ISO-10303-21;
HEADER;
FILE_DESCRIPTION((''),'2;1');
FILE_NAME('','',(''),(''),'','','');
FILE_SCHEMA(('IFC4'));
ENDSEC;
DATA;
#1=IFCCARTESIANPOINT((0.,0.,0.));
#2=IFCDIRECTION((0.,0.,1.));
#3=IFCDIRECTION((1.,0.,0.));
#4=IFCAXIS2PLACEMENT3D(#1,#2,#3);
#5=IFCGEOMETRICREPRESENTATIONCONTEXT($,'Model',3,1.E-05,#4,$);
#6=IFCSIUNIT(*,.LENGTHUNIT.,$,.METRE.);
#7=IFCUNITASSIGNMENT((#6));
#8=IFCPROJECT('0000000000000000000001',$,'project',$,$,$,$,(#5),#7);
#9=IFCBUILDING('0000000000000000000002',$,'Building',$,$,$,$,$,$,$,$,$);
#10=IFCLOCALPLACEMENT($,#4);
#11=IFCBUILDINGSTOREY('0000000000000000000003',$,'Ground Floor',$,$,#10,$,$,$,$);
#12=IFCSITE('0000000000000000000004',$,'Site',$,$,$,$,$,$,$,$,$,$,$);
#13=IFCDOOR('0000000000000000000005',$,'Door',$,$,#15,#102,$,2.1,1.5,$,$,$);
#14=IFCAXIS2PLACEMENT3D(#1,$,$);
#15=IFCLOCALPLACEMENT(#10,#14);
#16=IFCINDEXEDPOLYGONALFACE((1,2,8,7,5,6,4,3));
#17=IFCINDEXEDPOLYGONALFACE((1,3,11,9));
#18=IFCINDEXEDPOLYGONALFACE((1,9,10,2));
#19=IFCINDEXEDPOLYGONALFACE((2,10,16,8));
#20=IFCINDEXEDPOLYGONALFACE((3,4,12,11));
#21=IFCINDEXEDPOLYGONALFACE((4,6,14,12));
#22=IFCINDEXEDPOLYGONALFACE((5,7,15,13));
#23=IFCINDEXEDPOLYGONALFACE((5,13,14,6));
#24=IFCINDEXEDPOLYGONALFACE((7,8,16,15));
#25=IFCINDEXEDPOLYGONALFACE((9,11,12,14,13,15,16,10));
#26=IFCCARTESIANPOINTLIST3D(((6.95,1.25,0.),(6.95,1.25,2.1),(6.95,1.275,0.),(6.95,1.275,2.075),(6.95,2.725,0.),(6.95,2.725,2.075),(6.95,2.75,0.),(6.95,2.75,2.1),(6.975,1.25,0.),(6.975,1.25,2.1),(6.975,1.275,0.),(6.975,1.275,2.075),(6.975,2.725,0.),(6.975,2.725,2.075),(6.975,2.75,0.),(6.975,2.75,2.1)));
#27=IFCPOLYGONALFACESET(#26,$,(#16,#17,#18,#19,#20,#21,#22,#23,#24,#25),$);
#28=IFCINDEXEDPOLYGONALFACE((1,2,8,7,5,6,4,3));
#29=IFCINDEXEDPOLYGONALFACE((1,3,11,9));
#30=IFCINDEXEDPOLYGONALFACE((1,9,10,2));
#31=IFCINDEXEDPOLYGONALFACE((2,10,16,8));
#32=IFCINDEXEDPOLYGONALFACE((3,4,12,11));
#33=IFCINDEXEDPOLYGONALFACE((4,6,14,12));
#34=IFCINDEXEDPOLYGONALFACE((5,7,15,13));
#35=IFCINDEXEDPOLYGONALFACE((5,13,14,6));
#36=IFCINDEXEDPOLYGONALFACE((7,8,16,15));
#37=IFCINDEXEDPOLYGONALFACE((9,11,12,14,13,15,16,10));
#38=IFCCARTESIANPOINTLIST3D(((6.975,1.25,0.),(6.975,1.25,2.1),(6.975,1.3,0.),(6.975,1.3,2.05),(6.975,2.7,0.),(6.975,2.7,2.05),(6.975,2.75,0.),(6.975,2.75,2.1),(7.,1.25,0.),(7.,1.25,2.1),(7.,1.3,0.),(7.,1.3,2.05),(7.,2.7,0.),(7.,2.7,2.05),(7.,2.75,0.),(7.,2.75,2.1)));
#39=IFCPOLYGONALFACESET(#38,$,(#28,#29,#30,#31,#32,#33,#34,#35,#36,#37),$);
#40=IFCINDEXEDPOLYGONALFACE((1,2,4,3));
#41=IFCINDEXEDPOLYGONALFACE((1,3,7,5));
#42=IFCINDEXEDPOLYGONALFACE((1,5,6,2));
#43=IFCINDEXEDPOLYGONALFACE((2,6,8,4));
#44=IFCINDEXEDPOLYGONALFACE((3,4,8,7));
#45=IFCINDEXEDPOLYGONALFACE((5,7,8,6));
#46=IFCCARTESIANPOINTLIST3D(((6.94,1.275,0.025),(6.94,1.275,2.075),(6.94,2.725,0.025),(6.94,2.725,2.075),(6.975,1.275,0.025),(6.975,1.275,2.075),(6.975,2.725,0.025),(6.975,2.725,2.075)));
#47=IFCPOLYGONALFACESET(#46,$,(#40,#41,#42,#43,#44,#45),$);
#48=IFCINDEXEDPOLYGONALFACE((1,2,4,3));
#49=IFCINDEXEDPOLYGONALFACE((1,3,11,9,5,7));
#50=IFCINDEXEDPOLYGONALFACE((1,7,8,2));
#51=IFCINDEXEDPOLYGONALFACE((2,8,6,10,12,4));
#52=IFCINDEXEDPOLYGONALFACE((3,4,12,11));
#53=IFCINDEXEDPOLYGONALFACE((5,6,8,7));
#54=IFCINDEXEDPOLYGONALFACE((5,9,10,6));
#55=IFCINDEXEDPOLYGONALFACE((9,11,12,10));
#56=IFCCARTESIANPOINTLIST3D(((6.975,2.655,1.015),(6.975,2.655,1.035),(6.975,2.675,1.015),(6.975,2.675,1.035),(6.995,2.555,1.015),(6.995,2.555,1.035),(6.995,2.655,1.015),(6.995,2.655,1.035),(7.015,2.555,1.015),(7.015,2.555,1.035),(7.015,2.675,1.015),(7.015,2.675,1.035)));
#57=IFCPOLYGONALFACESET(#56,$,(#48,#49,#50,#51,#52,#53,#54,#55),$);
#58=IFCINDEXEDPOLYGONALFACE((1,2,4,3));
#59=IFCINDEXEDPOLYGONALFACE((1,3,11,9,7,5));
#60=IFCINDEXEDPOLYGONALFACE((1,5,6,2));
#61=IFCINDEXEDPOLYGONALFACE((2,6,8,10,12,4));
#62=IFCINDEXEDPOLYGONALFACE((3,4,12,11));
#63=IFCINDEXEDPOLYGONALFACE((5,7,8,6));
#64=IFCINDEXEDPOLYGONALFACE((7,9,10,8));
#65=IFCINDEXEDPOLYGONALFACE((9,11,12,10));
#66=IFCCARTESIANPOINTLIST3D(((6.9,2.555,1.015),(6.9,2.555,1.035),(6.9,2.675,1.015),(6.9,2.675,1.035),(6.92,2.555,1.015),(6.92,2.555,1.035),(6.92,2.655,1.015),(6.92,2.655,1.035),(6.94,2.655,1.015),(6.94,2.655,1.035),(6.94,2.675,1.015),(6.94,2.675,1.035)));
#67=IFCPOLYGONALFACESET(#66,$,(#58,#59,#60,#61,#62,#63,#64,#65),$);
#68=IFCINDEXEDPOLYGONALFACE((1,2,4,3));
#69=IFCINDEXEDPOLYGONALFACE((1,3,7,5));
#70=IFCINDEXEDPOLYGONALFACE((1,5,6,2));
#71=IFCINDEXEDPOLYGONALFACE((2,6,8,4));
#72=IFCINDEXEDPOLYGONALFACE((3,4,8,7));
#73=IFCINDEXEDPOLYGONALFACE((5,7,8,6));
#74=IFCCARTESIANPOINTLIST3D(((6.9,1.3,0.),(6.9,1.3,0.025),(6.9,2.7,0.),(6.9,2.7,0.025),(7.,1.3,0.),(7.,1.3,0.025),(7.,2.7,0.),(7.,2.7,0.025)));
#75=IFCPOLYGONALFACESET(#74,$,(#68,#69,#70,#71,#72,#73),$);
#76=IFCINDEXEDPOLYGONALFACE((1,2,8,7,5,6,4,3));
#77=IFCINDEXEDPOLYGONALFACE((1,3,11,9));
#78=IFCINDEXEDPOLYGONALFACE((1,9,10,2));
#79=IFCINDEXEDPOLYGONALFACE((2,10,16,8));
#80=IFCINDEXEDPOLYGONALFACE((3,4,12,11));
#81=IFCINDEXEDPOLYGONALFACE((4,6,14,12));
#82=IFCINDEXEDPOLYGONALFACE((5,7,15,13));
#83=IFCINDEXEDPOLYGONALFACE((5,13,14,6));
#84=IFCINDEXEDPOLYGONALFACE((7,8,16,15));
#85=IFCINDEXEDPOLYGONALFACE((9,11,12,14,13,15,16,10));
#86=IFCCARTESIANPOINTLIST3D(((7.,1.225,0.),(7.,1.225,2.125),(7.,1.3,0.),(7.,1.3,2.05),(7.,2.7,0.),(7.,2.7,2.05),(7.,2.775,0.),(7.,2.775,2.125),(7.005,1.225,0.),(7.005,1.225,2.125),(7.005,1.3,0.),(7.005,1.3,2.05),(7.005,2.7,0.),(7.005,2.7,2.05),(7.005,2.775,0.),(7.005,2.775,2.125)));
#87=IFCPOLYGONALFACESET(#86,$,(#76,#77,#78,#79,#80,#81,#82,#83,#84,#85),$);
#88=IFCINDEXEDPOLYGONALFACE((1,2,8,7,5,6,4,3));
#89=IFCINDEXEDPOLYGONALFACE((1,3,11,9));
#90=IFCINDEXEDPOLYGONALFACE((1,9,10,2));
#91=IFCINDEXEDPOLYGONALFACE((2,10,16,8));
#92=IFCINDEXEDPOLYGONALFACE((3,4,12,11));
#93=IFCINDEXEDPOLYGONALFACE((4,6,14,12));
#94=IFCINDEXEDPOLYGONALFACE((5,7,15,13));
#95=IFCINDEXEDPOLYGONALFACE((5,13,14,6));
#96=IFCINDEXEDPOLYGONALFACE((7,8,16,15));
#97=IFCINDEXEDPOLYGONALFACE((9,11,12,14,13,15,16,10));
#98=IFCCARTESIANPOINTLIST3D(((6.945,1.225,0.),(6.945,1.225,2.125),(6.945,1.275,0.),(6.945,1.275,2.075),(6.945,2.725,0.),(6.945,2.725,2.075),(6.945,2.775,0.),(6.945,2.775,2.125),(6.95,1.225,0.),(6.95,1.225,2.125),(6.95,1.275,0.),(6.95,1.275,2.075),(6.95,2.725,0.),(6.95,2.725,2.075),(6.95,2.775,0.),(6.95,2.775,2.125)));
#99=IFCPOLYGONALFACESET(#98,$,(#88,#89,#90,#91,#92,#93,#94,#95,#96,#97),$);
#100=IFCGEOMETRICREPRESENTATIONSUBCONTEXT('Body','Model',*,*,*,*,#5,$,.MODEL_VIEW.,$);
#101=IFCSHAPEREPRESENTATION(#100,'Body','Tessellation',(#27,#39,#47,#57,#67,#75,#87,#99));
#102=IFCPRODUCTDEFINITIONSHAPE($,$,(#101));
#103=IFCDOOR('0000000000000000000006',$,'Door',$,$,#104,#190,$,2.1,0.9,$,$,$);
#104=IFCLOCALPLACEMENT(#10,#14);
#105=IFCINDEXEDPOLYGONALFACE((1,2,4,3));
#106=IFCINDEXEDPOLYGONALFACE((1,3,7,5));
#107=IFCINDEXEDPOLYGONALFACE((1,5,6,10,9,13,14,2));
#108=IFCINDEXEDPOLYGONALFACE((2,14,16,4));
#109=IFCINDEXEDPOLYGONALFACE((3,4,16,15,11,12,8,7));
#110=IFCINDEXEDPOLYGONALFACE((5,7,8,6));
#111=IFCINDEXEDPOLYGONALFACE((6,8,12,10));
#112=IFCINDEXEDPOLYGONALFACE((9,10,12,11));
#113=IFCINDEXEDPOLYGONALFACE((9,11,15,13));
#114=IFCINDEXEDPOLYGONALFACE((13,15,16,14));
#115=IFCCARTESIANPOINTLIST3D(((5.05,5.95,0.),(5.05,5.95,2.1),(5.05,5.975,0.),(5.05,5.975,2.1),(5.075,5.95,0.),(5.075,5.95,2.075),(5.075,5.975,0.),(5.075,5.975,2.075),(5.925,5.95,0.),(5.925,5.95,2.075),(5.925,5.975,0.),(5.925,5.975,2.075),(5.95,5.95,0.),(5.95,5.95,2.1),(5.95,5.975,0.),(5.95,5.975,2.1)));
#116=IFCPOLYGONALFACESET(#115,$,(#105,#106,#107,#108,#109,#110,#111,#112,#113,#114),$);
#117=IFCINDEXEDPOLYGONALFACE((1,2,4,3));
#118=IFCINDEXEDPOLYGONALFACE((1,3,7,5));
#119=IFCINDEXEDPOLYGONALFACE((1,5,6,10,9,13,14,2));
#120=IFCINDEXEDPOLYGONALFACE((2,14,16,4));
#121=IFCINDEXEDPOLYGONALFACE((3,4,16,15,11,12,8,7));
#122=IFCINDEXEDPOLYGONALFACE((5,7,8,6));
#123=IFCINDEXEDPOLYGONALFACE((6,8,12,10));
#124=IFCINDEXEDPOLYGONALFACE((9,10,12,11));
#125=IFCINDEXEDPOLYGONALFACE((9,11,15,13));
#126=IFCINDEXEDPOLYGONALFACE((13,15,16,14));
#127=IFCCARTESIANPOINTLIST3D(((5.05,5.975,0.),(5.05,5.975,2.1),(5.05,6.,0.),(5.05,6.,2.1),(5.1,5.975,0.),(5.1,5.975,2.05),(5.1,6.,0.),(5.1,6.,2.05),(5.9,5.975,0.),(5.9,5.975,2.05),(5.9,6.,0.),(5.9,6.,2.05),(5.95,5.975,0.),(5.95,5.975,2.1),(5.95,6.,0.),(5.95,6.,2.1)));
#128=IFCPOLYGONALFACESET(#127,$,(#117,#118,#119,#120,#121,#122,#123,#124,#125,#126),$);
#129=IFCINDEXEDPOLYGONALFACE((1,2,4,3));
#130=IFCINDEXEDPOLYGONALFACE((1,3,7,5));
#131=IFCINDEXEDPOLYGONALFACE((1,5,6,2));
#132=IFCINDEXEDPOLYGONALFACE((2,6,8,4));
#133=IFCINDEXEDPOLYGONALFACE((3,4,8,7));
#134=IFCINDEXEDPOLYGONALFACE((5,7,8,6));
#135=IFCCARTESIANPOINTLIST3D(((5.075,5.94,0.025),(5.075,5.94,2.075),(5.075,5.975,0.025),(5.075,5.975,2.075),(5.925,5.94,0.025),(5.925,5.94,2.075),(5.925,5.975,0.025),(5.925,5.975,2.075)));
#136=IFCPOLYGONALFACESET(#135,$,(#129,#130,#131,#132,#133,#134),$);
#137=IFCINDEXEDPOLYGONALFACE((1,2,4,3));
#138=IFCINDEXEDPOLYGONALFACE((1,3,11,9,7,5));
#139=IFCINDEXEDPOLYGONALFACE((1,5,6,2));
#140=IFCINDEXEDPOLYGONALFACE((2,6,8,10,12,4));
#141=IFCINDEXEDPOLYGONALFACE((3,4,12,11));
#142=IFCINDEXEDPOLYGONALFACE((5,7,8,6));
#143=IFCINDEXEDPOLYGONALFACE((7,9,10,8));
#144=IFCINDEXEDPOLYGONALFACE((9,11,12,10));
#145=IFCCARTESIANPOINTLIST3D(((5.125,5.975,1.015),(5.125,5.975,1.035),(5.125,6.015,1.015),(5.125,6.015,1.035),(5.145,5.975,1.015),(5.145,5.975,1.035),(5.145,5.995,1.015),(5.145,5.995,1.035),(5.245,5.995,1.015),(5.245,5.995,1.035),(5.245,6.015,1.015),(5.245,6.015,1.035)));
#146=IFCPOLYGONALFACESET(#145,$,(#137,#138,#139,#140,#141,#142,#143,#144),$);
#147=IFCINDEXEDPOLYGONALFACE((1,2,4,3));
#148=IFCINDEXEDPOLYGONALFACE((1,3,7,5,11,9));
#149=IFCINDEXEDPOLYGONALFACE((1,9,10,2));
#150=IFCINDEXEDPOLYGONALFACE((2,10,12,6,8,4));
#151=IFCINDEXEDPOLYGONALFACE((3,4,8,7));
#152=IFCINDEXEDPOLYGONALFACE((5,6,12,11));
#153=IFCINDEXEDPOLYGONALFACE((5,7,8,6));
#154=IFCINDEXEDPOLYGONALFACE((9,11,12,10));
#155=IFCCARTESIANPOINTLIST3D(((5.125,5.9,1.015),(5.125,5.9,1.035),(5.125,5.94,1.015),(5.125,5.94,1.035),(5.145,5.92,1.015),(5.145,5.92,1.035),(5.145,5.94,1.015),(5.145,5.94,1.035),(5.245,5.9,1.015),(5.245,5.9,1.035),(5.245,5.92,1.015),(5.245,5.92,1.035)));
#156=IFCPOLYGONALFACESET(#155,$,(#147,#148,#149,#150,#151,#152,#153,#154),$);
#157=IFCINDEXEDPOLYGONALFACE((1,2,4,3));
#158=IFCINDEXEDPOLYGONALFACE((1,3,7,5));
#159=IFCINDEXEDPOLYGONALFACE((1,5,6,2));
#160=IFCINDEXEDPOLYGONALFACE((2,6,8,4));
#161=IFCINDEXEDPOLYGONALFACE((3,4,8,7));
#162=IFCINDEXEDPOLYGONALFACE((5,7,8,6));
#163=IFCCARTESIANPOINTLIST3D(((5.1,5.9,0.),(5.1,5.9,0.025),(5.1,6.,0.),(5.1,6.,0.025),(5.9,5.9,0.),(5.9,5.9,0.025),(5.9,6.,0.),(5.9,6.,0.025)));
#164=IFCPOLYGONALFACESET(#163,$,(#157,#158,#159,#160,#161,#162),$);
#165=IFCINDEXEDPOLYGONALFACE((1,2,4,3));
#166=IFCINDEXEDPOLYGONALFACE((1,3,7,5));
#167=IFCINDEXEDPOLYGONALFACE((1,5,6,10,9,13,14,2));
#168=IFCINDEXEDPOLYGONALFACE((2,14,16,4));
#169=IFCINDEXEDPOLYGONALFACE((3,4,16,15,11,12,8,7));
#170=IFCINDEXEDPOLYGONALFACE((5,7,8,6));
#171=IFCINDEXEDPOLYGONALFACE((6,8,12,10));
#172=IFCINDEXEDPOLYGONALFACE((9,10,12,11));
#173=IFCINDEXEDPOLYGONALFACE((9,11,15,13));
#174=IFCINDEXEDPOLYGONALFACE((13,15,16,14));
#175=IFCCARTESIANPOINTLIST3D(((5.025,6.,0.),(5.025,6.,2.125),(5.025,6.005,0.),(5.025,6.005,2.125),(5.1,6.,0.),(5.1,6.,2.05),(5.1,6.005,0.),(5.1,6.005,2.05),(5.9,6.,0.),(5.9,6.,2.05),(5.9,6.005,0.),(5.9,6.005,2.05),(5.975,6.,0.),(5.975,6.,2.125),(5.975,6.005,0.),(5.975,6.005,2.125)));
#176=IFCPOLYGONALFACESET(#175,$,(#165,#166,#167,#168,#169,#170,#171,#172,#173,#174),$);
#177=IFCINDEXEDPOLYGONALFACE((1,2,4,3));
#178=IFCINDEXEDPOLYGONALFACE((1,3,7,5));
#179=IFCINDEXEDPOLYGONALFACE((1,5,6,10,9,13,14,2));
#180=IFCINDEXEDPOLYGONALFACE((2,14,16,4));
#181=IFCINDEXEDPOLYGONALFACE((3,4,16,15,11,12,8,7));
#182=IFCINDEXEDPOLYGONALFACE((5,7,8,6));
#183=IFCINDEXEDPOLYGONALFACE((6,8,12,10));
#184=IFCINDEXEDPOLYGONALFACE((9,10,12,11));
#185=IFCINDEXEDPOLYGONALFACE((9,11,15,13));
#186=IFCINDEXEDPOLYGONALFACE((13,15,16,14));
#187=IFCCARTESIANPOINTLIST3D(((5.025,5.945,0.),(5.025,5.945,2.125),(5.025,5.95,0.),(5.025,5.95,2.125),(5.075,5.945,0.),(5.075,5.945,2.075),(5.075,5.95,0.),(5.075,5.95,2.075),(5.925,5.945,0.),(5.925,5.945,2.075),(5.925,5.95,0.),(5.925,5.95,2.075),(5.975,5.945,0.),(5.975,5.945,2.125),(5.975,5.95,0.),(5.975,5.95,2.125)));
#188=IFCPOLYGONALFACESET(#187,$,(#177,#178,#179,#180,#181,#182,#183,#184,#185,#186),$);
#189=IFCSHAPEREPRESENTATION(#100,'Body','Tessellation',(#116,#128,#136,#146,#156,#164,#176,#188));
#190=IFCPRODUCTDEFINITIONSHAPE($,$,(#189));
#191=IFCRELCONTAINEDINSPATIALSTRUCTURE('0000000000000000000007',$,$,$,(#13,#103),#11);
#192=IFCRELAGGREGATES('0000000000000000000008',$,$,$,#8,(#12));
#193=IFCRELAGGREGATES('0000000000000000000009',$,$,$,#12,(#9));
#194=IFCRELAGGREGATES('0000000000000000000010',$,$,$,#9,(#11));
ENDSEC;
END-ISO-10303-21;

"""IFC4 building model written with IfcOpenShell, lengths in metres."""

from ifc_helpers import new_model, si_unit, frame, origin_with_axes, place, context, subcontext, project, spatial, line, indexed_curve, outline, extrude, element, save


model = new_model("IFC4")

# Units and contexts
model_context = context("Model", 3, precision=1e-05, world=origin_with_axes())
body_context = subcontext(model_context, "Body", "Model", "MODEL_VIEW")
ifc_project = project(units=[si_unit("LENGTHUNIT", "METRE")], contexts=[model_context])

# Site, building, storey
site = spatial("IfcSite", under=ifc_project, Name="Site")
building = spatial("IfcBuilding", under=site, Name="Building")
storey_placement = place(None, origin_with_axes())
storey = spatial("IfcBuildingStorey", under=building, at=storey_placement, Name="Ground Floor")

# Doors
door_1_placement = place(storey_placement, frame((7.0, 1.25, 0.0), z_axis=(0.0, 0.0, 1.0), x_axis=(0.0, 1.0, 0.0)))
element("IfcDoor", 1, at=door_1_placement, inside=storey, Name="Door", OverallHeight=2.1, OverallWidth=1.5, context=body_context, shape_type="SweptSolid", body=[
    extrude(outline(indexed_curve([(0.0, 0.0), (0.0, 2.1), (1.5, 2.1), (1.5, 0.0), (1.475, 0.0), (1.475, 2.075), (0.025, 2.075), (0.025, 0.0)], segments=[line(1, 2, 3, 4, 5, 6, 7, 8, 1)])), frame((0.0, 0.025, 0.0), z_axis=(0.0, -1.0, 0.0), x_axis=(1.0, 0.0, 0.0)), (0.0, 0.0, -1.0), 0.025),
    extrude(outline(indexed_curve([(0.0, 0.0), (0.0, 2.1), (1.5, 2.1), (1.5, 0.0), (1.45, 0.0), (1.45, 2.05), (0.05, 2.05), (0.05, 0.0)], segments=[line(1, 2, 3, 4, 5, 6, 7, 8, 1)])), frame((0.0, 0.0, 0.0), z_axis=(0.0, -1.0, 0.0), x_axis=(1.0, 0.0, 0.0)), (0.0, 0.0, -1.0), 0.025),
    extrude(outline(indexed_curve([(0.0, 0.0), (1.45, 0.0), (1.45, 0.035), (0.0, 0.035)], segments=[line(1, 2, 3, 4, 1)])), frame((0.025, 0.025, 0.025), z_axis=(0.0, 0.0, 1.0), x_axis=(1.0, 0.0, 0.0)), (0.0, 0.0, 1.0), 2.05),
    extrude(outline(indexed_curve([(0.0, 0.0), (0.0, -0.04), (-0.12, -0.04), (-0.12, -0.02), (-0.02, -0.02), (-0.02, 0.0)], segments=[line(1, 2, 3, 4, 5, 6, 1)])), frame((1.425, 0.025, 1.015), z_axis=(0.0, 0.0, 1.0), x_axis=(1.0, 0.0, 0.0)), (0.0, 0.0, 1.0), 0.02),
    extrude(outline(indexed_curve([(0.0, 0.0), (0.0, 0.04), (-0.12, 0.04), (-0.12, 0.02), (-0.02, 0.02), (-0.02, 0.0)], segments=[line(1, 2, 3, 4, 5, 6, 1)])), frame((1.425, 0.06, 1.015), z_axis=(0.0, 0.0, 1.0), x_axis=(1.0, 0.0, 0.0)), (0.0, 0.0, 1.0), 0.02),
    extrude(outline(indexed_curve([(0.0, 0.0), (1.4, 0.0), (1.4, 0.1), (0.0, 0.1)], segments=[line(1, 2, 3, 4, 1)])), frame((0.05, 0.0, 0.0), z_axis=(0.0, 0.0, 1.0), x_axis=(1.0, 0.0, 0.0)), (0.0, 0.0, 1.0), 0.025),
    extrude(outline(indexed_curve([(0.0, 0.0), (0.0, 2.125), (1.55, 2.125), (1.55, 0.0), (1.475, 0.0), (1.475, 2.05), (0.075, 2.05), (0.075, 0.0)], segments=[line(1, 2, 3, 4, 5, 6, 7, 8, 1)])), frame((-0.025, -0.005, 0.0), z_axis=(0.0, -1.0, 0.0), x_axis=(1.0, 0.0, 0.0)), (0.0, 0.0, -1.0), 0.005),
    extrude(outline(indexed_curve([(0.0, 0.0), (0.0, 2.125), (1.55, 2.125), (1.55, 0.0), (1.5, 0.0), (1.5, 2.075), (0.05, 2.075), (0.05, 0.0)], segments=[line(1, 2, 3, 4, 5, 6, 7, 8, 1)])), frame((-0.025, 0.05, 0.0), z_axis=(0.0, -1.0, 0.0), x_axis=(1.0, 0.0, 0.0)), (0.0, 0.0, -1.0), 0.005),
])
door_2_placement = place(storey_placement, frame((5.95, 6.0, 0.0), z_axis=(0.0, 0.0, 1.0), x_axis=(-1.0, 0.0, 0.0)))
element("IfcDoor", 2, at=door_2_placement, inside=storey, Name="Door", OverallHeight=2.1, OverallWidth=0.9, context=body_context, shape_type="SweptSolid", body=[
    extrude(outline(indexed_curve([(0.0, 0.0), (0.0, 2.1), (0.9, 2.1), (0.9, 0.0), (0.875, 0.0), (0.875, 2.075), (0.025, 2.075), (0.025, 0.0)], segments=[line(1, 2, 3, 4, 5, 6, 7, 8, 1)])), frame((0.0, 0.025, 0.0), z_axis=(0.0, -1.0, 0.0), x_axis=(1.0, 0.0, 0.0)), (0.0, 0.0, -1.0), 0.025),
    extrude(outline(indexed_curve([(0.0, 0.0), (0.0, 2.1), (0.9, 2.1), (0.9, 0.0), (0.85, 0.0), (0.85, 2.05), (0.05, 2.05), (0.05, 0.0)], segments=[line(1, 2, 3, 4, 5, 6, 7, 8, 1)])), frame((0.0, 0.0, 0.0), z_axis=(0.0, -1.0, 0.0), x_axis=(1.0, 0.0, 0.0)), (0.0, 0.0, -1.0), 0.025),
    extrude(outline(indexed_curve([(0.0, 0.0), (0.85, 0.0), (0.85, 0.035), (0.0, 0.035)], segments=[line(1, 2, 3, 4, 1)])), frame((0.025, 0.025, 0.025), z_axis=(0.0, 0.0, 1.0), x_axis=(1.0, 0.0, 0.0)), (0.0, 0.0, 1.0), 2.05),
    extrude(outline(indexed_curve([(0.0, 0.0), (0.0, -0.04), (-0.12, -0.04), (-0.12, -0.02), (-0.02, -0.02), (-0.02, 0.0)], segments=[line(1, 2, 3, 4, 5, 6, 1)])), frame((0.825, 0.025, 1.015), z_axis=(0.0, 0.0, 1.0), x_axis=(1.0, 0.0, 0.0)), (0.0, 0.0, 1.0), 0.02),
    extrude(outline(indexed_curve([(0.0, 0.0), (0.0, 0.04), (-0.12, 0.04), (-0.12, 0.02), (-0.02, 0.02), (-0.02, 0.0)], segments=[line(1, 2, 3, 4, 5, 6, 1)])), frame((0.825, 0.06, 1.015), z_axis=(0.0, 0.0, 1.0), x_axis=(1.0, 0.0, 0.0)), (0.0, 0.0, 1.0), 0.02),
    extrude(outline(indexed_curve([(0.0, 0.0), (0.8, 0.0), (0.8, 0.1), (0.0, 0.1)], segments=[line(1, 2, 3, 4, 1)])), frame((0.05, 0.0, 0.0), z_axis=(0.0, 0.0, 1.0), x_axis=(1.0, 0.0, 0.0)), (0.0, 0.0, 1.0), 0.025),
    extrude(outline(indexed_curve([(0.0, 0.0), (0.0, 2.125), (0.95, 2.125), (0.95, 0.0), (0.875, 0.0), (0.875, 2.05), (0.075, 2.05), (0.075, 0.0)], segments=[line(1, 2, 3, 4, 5, 6, 7, 8, 1)])), frame((-0.025, -0.005, 0.0), z_axis=(0.0, -1.0, 0.0), x_axis=(1.0, 0.0, 0.0)), (0.0, 0.0, -1.0), 0.005),
    extrude(outline(indexed_curve([(0.0, 0.0), (0.0, 2.125), (0.95, 2.125), (0.95, 0.0), (0.9, 0.0), (0.9, 2.075), (0.05, 2.075), (0.05, 0.0)], segments=[line(1, 2, 3, 4, 5, 6, 7, 8, 1)])), frame((-0.025, 0.05, 0.0), z_axis=(0.0, -1.0, 0.0), x_axis=(1.0, 0.0, 0.0)), (0.0, 0.0, -1.0), 0.005),
])

save(model, "model.ifc")
